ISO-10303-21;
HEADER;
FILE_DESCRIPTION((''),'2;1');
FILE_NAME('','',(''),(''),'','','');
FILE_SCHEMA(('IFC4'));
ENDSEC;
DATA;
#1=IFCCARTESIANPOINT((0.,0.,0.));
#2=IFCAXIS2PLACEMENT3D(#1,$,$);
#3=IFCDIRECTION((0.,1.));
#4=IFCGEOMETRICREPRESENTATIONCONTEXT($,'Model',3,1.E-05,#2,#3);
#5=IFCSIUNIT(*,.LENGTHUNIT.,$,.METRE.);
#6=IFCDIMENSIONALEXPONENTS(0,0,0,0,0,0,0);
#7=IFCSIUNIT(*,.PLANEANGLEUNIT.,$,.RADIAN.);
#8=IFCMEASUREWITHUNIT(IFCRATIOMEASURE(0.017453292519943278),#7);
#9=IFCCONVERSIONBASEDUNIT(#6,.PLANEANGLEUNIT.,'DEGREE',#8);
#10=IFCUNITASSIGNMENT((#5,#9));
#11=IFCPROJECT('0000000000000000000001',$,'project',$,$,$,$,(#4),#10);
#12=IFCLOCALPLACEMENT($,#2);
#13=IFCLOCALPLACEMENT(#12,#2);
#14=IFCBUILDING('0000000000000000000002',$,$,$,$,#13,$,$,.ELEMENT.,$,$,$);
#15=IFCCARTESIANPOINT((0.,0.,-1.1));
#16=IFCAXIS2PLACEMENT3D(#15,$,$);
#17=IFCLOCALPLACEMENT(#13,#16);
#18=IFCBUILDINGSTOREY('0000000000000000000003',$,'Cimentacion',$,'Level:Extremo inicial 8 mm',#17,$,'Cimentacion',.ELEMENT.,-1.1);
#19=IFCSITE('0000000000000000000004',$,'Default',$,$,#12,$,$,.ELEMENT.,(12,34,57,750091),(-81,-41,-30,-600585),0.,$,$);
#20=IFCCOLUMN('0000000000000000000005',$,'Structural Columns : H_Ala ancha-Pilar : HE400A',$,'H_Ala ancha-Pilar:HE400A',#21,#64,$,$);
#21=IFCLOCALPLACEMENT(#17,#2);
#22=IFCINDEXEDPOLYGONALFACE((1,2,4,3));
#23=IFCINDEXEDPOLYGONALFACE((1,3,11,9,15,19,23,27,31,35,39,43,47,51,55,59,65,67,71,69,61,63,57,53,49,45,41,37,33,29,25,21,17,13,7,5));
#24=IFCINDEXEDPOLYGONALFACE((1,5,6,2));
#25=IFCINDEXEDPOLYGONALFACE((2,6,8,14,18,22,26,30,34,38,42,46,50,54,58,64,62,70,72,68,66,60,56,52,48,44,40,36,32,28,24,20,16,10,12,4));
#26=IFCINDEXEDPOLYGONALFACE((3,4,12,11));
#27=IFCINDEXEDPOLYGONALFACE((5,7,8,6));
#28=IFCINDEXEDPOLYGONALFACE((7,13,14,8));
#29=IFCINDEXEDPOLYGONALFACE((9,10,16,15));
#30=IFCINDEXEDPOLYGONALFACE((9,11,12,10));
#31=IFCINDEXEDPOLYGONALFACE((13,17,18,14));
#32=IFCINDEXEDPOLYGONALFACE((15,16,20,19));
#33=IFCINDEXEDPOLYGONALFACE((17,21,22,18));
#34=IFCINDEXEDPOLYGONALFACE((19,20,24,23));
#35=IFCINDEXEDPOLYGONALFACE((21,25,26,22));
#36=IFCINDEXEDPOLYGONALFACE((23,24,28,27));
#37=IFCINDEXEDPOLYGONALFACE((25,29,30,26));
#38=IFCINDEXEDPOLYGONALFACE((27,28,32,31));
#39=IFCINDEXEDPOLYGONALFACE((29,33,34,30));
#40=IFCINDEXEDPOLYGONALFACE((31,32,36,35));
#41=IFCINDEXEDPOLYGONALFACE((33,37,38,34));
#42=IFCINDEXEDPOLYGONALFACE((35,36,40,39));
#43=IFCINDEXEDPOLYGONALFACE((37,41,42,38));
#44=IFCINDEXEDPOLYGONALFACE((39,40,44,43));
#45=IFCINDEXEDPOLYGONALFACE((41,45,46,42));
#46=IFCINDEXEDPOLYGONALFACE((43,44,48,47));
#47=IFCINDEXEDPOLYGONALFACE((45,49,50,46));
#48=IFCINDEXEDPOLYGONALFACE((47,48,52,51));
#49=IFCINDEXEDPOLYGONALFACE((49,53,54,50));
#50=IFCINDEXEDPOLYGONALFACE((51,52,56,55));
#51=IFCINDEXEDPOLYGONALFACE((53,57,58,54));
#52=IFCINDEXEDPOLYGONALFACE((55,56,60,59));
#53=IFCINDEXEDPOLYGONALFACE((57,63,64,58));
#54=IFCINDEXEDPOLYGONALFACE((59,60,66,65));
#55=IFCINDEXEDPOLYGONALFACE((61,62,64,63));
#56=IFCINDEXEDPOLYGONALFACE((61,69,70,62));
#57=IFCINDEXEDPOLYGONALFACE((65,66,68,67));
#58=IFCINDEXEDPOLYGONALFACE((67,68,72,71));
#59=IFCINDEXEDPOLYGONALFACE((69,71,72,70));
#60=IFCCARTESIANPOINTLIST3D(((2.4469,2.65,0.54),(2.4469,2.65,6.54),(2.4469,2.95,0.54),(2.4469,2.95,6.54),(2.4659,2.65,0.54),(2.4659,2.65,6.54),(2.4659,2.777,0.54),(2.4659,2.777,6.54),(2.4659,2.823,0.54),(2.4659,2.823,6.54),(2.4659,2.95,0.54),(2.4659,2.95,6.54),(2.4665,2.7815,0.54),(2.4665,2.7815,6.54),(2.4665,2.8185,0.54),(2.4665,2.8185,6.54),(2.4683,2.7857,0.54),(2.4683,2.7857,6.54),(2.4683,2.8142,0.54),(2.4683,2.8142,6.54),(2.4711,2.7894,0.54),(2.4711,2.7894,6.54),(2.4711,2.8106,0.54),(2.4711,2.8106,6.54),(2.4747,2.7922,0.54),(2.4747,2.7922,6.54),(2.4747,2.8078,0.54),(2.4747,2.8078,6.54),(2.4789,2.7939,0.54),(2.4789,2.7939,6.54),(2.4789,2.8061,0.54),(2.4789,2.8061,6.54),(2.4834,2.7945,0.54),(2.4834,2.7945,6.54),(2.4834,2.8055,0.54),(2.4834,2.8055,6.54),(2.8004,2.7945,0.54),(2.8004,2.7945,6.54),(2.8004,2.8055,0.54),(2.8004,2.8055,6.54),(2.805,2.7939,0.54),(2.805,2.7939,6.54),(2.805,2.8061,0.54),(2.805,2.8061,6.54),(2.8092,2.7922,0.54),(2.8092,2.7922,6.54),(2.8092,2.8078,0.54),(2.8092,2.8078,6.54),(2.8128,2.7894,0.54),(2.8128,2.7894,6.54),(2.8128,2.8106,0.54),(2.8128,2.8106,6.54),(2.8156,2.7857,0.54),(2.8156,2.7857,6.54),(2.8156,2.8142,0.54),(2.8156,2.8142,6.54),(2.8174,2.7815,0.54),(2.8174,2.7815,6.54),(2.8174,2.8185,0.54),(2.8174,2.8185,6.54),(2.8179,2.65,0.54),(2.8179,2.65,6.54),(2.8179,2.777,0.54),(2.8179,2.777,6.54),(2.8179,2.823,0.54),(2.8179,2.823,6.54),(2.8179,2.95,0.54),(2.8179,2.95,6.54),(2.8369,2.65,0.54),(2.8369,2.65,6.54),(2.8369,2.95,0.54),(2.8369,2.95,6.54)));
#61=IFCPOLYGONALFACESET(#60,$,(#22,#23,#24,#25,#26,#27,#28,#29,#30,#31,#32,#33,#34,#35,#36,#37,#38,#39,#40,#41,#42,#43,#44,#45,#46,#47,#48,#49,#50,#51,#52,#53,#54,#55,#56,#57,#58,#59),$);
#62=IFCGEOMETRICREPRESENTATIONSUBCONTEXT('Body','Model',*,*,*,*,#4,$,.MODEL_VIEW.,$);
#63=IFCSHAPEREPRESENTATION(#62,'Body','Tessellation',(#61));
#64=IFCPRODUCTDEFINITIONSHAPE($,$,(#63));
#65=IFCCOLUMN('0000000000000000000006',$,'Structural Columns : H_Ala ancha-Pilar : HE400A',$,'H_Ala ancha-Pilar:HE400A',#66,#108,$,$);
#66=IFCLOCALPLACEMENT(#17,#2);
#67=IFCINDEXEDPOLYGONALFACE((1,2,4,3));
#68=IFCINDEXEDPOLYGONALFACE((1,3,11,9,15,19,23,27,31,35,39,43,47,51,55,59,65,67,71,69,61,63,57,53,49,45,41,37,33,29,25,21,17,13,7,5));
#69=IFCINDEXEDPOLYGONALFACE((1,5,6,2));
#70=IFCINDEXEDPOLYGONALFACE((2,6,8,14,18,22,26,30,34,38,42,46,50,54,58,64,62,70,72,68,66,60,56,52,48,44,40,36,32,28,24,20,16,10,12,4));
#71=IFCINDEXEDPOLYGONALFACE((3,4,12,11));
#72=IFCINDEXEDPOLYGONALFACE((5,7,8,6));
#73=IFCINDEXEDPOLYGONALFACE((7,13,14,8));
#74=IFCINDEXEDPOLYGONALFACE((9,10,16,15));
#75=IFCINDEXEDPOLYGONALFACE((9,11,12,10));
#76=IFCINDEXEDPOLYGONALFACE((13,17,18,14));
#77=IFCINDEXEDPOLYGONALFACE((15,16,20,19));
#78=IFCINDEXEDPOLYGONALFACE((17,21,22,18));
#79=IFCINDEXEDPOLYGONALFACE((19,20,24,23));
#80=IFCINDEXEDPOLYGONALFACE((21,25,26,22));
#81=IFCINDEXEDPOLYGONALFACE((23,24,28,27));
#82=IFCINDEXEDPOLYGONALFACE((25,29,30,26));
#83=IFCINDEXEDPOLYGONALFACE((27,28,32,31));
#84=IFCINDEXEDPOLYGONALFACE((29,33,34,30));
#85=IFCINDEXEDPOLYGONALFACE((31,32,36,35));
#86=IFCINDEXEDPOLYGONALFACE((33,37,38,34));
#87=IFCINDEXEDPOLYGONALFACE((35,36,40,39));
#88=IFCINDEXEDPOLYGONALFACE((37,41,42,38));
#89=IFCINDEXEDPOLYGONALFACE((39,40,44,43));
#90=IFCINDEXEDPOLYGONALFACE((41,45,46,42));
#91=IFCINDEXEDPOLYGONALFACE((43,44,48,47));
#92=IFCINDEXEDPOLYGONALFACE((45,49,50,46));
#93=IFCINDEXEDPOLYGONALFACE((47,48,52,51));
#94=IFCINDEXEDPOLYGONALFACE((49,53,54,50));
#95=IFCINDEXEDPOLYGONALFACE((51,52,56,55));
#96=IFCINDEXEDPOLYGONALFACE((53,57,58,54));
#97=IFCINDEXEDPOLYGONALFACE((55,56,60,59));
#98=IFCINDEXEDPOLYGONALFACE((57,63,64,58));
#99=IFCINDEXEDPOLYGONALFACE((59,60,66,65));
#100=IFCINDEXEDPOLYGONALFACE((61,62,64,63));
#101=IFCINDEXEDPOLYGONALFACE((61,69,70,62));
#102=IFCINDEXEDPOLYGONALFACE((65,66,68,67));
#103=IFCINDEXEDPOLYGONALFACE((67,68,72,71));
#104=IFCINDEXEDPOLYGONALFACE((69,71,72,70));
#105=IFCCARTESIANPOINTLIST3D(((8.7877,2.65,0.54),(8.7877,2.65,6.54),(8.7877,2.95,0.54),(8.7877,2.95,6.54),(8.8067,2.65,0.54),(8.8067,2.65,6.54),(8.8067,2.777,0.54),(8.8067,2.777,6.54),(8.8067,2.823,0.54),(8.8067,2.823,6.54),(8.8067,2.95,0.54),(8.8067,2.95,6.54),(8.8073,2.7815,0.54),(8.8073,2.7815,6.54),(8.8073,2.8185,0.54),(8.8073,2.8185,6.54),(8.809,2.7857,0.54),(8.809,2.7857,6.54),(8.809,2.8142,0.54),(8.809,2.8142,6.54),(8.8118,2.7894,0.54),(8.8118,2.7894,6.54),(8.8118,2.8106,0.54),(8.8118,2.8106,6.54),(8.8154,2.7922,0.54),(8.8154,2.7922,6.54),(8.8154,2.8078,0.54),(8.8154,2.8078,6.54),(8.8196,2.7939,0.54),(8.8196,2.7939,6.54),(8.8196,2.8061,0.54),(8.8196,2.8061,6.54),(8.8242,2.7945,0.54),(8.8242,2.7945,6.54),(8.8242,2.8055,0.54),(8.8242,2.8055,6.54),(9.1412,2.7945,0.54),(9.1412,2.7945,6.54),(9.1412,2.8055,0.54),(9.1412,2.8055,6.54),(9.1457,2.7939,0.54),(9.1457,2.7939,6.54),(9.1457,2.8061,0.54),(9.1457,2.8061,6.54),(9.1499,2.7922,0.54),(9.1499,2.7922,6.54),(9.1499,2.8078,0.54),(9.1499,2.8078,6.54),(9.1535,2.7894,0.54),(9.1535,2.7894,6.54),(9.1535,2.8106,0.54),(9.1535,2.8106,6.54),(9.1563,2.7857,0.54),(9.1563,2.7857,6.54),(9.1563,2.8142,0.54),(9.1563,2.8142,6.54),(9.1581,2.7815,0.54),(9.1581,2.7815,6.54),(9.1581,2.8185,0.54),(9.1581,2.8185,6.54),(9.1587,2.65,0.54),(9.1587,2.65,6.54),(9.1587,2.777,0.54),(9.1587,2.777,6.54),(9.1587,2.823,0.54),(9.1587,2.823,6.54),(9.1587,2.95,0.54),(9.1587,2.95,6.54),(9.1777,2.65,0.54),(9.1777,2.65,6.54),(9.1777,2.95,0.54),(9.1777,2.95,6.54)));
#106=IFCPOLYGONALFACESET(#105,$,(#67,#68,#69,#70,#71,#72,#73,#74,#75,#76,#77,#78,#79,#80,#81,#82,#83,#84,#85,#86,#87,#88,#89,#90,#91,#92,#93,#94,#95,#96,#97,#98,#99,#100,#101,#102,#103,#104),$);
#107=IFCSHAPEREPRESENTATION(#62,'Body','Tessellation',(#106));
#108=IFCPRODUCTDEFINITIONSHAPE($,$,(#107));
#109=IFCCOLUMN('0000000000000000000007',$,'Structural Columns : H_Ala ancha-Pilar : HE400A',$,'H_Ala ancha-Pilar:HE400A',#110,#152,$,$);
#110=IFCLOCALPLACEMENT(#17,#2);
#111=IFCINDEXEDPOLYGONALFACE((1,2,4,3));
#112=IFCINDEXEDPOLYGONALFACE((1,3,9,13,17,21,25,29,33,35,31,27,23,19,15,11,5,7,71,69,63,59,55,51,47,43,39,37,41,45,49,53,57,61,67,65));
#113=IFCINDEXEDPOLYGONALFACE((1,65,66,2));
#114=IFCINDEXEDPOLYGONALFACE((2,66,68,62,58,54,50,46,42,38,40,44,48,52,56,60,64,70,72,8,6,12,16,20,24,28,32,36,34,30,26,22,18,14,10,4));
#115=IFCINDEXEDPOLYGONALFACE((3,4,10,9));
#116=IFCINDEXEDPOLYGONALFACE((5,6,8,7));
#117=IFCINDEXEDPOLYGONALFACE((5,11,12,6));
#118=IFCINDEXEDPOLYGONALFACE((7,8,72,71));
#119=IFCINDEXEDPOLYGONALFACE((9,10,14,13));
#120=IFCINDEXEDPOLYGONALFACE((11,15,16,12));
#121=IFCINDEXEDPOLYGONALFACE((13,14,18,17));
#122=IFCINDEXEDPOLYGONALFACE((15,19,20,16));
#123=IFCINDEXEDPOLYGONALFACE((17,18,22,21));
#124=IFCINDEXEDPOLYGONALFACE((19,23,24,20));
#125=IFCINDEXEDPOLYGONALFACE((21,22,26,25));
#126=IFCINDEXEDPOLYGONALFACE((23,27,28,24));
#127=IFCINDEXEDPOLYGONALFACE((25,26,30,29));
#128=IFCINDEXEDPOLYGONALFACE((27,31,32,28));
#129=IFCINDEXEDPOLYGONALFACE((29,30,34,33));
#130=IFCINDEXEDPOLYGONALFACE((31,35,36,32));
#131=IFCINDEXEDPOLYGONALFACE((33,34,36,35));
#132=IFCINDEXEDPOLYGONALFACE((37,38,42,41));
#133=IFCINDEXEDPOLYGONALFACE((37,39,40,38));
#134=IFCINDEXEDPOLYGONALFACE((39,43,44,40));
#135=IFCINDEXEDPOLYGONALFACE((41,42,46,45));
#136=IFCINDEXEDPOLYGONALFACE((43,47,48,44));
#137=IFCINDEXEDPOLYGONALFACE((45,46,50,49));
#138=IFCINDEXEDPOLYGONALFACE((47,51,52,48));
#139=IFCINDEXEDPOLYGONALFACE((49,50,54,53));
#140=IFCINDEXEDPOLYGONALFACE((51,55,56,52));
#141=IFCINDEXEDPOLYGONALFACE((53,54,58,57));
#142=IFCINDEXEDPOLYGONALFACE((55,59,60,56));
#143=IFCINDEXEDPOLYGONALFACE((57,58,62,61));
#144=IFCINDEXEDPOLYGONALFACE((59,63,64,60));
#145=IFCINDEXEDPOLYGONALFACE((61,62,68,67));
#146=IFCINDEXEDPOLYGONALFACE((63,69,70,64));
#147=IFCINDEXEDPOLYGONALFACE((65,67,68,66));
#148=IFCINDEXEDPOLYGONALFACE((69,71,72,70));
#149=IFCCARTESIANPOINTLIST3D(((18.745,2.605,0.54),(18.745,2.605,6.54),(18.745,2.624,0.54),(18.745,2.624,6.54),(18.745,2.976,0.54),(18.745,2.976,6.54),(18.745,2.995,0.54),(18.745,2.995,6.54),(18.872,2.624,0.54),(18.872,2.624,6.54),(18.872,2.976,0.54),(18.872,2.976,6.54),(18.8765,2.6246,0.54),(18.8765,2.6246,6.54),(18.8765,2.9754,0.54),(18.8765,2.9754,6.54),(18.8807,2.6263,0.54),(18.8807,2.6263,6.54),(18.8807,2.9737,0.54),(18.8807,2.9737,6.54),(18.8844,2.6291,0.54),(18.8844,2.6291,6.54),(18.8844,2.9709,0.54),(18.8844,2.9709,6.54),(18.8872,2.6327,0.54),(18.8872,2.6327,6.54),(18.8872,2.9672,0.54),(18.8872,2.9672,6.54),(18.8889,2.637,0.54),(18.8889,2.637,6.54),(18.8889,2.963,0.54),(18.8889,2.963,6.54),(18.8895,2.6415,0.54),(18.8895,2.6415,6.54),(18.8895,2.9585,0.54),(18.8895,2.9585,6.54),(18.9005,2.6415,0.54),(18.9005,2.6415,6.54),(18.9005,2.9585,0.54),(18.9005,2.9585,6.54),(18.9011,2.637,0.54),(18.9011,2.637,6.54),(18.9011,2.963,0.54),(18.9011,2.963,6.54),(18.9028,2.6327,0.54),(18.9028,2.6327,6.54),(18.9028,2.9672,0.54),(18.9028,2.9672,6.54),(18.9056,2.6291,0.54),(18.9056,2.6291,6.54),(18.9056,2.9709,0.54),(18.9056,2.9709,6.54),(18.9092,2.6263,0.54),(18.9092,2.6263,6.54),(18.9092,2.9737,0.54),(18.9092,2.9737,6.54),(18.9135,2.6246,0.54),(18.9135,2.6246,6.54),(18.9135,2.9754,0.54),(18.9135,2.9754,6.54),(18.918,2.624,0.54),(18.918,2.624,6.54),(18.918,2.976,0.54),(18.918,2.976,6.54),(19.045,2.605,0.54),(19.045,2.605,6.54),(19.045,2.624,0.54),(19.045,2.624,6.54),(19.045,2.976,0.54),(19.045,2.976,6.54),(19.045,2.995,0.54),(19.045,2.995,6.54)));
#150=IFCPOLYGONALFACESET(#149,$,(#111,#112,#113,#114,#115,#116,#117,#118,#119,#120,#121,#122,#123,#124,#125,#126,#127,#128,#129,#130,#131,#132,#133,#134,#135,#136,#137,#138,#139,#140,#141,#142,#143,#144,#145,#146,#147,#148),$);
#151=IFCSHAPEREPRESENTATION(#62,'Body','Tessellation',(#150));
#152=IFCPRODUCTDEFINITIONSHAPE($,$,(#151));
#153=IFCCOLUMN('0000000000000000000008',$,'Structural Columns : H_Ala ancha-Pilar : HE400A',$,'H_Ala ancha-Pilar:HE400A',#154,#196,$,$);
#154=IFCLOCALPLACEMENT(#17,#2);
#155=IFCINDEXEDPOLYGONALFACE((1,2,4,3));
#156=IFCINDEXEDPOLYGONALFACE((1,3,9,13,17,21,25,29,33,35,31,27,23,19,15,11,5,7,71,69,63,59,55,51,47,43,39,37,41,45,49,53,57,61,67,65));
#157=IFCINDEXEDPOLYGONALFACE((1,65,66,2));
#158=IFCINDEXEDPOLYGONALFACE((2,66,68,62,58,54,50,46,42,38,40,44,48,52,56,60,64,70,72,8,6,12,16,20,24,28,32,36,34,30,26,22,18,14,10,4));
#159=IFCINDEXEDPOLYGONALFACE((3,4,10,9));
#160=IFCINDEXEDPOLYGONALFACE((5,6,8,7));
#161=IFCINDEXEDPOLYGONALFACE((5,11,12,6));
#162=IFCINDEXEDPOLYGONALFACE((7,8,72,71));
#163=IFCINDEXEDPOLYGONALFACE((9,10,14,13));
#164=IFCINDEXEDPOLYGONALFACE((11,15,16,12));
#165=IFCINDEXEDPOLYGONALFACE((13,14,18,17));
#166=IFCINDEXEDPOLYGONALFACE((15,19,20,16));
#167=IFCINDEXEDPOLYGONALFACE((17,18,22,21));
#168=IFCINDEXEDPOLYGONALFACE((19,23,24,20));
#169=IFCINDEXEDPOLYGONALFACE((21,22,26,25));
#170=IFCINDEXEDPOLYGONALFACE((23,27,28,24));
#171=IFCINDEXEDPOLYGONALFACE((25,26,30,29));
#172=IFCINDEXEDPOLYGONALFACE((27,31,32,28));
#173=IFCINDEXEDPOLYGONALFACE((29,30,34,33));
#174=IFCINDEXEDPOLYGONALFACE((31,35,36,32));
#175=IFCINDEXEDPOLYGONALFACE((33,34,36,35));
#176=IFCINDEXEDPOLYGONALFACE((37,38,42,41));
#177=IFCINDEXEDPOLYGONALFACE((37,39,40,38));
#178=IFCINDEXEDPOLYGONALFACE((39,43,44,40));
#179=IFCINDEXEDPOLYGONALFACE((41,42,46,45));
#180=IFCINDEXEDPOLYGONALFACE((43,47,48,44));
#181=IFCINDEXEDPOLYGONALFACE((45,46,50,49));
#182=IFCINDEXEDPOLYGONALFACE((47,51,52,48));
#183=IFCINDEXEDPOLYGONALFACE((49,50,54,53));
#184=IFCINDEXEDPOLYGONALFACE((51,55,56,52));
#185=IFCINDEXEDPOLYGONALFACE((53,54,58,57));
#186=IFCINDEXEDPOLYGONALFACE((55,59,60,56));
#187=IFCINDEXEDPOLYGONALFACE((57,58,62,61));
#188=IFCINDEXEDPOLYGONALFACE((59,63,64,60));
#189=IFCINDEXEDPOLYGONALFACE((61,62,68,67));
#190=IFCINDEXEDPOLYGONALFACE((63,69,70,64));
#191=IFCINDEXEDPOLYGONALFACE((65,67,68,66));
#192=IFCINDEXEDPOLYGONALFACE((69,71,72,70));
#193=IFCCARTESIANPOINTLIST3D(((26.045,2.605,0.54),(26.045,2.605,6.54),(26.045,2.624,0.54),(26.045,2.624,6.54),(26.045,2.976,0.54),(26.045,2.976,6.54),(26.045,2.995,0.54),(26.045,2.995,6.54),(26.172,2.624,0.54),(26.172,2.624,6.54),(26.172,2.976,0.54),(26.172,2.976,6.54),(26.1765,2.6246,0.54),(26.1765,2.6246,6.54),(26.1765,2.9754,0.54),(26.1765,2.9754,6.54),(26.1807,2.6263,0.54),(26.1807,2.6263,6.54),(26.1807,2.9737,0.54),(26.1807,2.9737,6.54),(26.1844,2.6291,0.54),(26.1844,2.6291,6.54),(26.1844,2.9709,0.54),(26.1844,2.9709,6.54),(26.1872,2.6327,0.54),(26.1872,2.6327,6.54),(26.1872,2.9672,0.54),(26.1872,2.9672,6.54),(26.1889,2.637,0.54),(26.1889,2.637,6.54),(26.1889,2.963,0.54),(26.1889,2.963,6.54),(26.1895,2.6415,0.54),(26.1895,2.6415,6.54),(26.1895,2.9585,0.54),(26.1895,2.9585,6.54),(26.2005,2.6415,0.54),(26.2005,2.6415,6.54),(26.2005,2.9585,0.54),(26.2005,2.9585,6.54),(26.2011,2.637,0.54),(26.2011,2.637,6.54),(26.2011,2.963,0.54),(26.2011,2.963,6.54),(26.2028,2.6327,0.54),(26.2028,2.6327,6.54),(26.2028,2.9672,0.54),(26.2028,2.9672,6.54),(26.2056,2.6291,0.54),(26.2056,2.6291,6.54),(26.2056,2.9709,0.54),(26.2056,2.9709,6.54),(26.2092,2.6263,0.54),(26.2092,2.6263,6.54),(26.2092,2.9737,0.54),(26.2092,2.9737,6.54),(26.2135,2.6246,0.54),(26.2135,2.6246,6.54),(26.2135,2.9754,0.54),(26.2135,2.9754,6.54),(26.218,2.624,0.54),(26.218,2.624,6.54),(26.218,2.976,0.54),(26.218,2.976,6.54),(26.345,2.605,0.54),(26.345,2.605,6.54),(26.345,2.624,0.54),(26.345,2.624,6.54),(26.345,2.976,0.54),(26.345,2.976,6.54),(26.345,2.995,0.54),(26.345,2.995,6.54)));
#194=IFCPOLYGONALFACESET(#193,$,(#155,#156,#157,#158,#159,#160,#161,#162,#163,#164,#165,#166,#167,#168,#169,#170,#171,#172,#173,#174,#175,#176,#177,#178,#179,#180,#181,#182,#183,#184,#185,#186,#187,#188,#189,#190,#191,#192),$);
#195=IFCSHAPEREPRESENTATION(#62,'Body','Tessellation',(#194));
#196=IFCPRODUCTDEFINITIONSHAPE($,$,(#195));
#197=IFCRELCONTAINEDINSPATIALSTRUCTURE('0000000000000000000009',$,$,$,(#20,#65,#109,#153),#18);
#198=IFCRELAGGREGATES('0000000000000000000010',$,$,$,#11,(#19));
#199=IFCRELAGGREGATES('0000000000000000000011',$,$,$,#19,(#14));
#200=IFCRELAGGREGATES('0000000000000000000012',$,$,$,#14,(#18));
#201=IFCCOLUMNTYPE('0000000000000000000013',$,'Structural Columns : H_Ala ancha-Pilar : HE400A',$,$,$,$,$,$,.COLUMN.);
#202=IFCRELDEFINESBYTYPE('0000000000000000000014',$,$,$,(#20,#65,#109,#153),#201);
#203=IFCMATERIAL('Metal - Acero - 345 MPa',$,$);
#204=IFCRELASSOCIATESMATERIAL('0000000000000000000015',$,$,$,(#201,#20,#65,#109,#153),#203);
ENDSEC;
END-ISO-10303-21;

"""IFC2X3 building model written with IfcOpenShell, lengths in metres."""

from ifc_helpers import new_model, entity, si_unit, converted_unit, direction, frame, frame_2d, origin, place, context, subcontext, project, spatial, polyline, circle_curve, parameter, trimmed, segment, composite_curve, outline, extrude, source, transform, mapped, material, type_object, type_shapes, element, save


model = new_model("IFC2X3")

# Units and contexts
model_context = context("Model", 3, precision=1e-05, world=origin(), true_north=direction((0.0, 1.0)))
body_context = subcontext(model_context, "Body", "Model", "MODEL_VIEW")
ifc_project = project(units=[si_unit("LENGTHUNIT", "METRE"), converted_unit("PLANEANGLEUNIT", "DEGREE", entity("IfcRatioMeasure", 0.017453292519943278), si_unit("PLANEANGLEUNIT", "RADIAN"), dimensions=[0, 0, 0, 0, 0, 0, 0])], contexts=[model_context])

# Site, building, storey
site_placement = place(None, origin())
site = spatial("IfcSite", under=ifc_project, at=site_placement, Name="Default", CompositionType="ELEMENT", RefLatitude=(12, 34, 57, 750091), RefLongitude=(-81, -41, -30, -600585), RefElevation=0.0)
building_placement = place(site_placement, origin())
building = spatial("IfcBuilding", under=site, at=building_placement, CompositionType="ELEMENT")
storey_placement = place(building_placement, frame((0.0, 0.0, -1.1)))
storey = spatial("IfcBuildingStorey", under=building, at=storey_placement, Name="Cimentacion", ObjectType="Level:Extremo inicial 8 mm", LongName="Cimentacion", CompositionType="ELEMENT", Elevation=-1.1)

# Columns
ifc_material = material(Name="Metal - Acero - 345 MPa")
column_type_1 = type_object("IfcColumnType", Name="Structural Columns : H_Ala ancha-Pilar : HE400A", PredefinedType="COLUMN", material=ifc_material)
shared_shape_1 = source(origin(), body_context, "Body", "SweptSolid", [
    extrude(outline(composite_curve([segment(polyline([(0.176, -0.15), (0.195, -0.15)]), True, "CONTINUOUS"), segment(polyline([(0.195, -0.15), (0.195, 0.15)]), True, "CONTINUOUS"), segment(polyline([(0.195, 0.15), (0.176, 0.15)]), True, "CONTINUOUS"), segment(polyline([(0.176, 0.15), (0.176, 0.023)]), True, "CONTINUOUS"), segment(trimmed(circle_curve(frame_2d((0.1585, 0.023), x_axis=(1.0, 0.0)), 0.0175), [parameter(270.0)], [parameter(0.0)], True, "PARAMETER"), False, "CONTINUOUS"), segment(polyline([(0.1585, 0.0055), (-0.1585, 0.0055)]), True, "CONTINUOUS"), segment(trimmed(circle_curve(frame_2d((-0.1585, 0.023), x_axis=(0.0, -1.0)), 0.0175), [parameter(270.0)], [parameter(0.0)], True, "PARAMETER"), False, "CONTINUOUS"), segment(polyline([(-0.176, 0.023), (-0.176, 0.15)]), True, "CONTINUOUS"), segment(polyline([(-0.176, 0.15), (-0.195, 0.15)]), True, "CONTINUOUS"), segment(polyline([(-0.195, 0.15), (-0.195, -0.15)]), True, "CONTINUOUS"), segment(polyline([(-0.195, -0.15), (-0.176, -0.15)]), True, "CONTINUOUS"), segment(polyline([(-0.176, -0.15), (-0.176, -0.023)]), True, "CONTINUOUS"), segment(trimmed(circle_curve(frame_2d((-0.1585, -0.023), x_axis=(-1.0, 0.0)), 0.0175), [parameter(270.0)], [parameter(0.0)], True, "PARAMETER"), False, "CONTINUOUS"), segment(polyline([(-0.1585, -0.0055), (0.1585, -0.0055)]), True, "CONTINUOUS"), segment(trimmed(circle_curve(frame_2d((0.1585, -0.023), x_axis=(0.0, 1.0)), 0.0175), [parameter(270.0)], [parameter(0.0)], True, "PARAMETER"), False, "CONTINUOUS"), segment(polyline([(0.176, -0.023), (0.176, -0.15)]), True, "CONTINUOUS")], self_intersect=False)), frame((0.0, 0.0, -0.56), z_axis=(0.0, 0.0, 1.0), x_axis=(0.0, -1.0, 0.0)), (0.0, 0.0, 1.0), 6.0),
])
type_shapes(column_type_1, [shared_shape_1])
for number, where, z_axis, x_axis, name in (
    (1, (2.6419, 2.8, 1.1), (0.0, 0.0, 1.0), (0.0, 1.0, 0.0), "Structural Columns : H_Ala ancha-Pilar : HE400A"),
    (2, (8.9827, 2.8, 1.1), (0.0, 0.0, 1.0), (0.0, 1.0, 0.0), "Structural Columns : H_Ala ancha-Pilar : HE400A"),
    (3, (18.895, 2.8, 1.1), (0.0, 0.0, 1.0), (-1.0, 0.0, 0.0), "Structural Columns : H_Ala ancha-Pilar : HE400A"),
    (4, (26.195, 2.8, 1.1), (0.0, 0.0, 1.0), (-1.0, 0.0, 0.0), "Structural Columns : H_Ala ancha-Pilar : HE400A"),
):
    element("IfcColumn", number, at=place(storey_placement, frame(where, z_axis=z_axis, x_axis=x_axis)), inside=storey, type_object=column_type_1, material=ifc_material, Name=name, ObjectType="H_Ala ancha-Pilar:HE400A", context=body_context, shape_type="MappedRepresentation", body=[
        mapped(shared_shape_1, transform((0.0, 0.0, 0.0), scale=1.0)),
    ])

save(model, "model.ifc")
